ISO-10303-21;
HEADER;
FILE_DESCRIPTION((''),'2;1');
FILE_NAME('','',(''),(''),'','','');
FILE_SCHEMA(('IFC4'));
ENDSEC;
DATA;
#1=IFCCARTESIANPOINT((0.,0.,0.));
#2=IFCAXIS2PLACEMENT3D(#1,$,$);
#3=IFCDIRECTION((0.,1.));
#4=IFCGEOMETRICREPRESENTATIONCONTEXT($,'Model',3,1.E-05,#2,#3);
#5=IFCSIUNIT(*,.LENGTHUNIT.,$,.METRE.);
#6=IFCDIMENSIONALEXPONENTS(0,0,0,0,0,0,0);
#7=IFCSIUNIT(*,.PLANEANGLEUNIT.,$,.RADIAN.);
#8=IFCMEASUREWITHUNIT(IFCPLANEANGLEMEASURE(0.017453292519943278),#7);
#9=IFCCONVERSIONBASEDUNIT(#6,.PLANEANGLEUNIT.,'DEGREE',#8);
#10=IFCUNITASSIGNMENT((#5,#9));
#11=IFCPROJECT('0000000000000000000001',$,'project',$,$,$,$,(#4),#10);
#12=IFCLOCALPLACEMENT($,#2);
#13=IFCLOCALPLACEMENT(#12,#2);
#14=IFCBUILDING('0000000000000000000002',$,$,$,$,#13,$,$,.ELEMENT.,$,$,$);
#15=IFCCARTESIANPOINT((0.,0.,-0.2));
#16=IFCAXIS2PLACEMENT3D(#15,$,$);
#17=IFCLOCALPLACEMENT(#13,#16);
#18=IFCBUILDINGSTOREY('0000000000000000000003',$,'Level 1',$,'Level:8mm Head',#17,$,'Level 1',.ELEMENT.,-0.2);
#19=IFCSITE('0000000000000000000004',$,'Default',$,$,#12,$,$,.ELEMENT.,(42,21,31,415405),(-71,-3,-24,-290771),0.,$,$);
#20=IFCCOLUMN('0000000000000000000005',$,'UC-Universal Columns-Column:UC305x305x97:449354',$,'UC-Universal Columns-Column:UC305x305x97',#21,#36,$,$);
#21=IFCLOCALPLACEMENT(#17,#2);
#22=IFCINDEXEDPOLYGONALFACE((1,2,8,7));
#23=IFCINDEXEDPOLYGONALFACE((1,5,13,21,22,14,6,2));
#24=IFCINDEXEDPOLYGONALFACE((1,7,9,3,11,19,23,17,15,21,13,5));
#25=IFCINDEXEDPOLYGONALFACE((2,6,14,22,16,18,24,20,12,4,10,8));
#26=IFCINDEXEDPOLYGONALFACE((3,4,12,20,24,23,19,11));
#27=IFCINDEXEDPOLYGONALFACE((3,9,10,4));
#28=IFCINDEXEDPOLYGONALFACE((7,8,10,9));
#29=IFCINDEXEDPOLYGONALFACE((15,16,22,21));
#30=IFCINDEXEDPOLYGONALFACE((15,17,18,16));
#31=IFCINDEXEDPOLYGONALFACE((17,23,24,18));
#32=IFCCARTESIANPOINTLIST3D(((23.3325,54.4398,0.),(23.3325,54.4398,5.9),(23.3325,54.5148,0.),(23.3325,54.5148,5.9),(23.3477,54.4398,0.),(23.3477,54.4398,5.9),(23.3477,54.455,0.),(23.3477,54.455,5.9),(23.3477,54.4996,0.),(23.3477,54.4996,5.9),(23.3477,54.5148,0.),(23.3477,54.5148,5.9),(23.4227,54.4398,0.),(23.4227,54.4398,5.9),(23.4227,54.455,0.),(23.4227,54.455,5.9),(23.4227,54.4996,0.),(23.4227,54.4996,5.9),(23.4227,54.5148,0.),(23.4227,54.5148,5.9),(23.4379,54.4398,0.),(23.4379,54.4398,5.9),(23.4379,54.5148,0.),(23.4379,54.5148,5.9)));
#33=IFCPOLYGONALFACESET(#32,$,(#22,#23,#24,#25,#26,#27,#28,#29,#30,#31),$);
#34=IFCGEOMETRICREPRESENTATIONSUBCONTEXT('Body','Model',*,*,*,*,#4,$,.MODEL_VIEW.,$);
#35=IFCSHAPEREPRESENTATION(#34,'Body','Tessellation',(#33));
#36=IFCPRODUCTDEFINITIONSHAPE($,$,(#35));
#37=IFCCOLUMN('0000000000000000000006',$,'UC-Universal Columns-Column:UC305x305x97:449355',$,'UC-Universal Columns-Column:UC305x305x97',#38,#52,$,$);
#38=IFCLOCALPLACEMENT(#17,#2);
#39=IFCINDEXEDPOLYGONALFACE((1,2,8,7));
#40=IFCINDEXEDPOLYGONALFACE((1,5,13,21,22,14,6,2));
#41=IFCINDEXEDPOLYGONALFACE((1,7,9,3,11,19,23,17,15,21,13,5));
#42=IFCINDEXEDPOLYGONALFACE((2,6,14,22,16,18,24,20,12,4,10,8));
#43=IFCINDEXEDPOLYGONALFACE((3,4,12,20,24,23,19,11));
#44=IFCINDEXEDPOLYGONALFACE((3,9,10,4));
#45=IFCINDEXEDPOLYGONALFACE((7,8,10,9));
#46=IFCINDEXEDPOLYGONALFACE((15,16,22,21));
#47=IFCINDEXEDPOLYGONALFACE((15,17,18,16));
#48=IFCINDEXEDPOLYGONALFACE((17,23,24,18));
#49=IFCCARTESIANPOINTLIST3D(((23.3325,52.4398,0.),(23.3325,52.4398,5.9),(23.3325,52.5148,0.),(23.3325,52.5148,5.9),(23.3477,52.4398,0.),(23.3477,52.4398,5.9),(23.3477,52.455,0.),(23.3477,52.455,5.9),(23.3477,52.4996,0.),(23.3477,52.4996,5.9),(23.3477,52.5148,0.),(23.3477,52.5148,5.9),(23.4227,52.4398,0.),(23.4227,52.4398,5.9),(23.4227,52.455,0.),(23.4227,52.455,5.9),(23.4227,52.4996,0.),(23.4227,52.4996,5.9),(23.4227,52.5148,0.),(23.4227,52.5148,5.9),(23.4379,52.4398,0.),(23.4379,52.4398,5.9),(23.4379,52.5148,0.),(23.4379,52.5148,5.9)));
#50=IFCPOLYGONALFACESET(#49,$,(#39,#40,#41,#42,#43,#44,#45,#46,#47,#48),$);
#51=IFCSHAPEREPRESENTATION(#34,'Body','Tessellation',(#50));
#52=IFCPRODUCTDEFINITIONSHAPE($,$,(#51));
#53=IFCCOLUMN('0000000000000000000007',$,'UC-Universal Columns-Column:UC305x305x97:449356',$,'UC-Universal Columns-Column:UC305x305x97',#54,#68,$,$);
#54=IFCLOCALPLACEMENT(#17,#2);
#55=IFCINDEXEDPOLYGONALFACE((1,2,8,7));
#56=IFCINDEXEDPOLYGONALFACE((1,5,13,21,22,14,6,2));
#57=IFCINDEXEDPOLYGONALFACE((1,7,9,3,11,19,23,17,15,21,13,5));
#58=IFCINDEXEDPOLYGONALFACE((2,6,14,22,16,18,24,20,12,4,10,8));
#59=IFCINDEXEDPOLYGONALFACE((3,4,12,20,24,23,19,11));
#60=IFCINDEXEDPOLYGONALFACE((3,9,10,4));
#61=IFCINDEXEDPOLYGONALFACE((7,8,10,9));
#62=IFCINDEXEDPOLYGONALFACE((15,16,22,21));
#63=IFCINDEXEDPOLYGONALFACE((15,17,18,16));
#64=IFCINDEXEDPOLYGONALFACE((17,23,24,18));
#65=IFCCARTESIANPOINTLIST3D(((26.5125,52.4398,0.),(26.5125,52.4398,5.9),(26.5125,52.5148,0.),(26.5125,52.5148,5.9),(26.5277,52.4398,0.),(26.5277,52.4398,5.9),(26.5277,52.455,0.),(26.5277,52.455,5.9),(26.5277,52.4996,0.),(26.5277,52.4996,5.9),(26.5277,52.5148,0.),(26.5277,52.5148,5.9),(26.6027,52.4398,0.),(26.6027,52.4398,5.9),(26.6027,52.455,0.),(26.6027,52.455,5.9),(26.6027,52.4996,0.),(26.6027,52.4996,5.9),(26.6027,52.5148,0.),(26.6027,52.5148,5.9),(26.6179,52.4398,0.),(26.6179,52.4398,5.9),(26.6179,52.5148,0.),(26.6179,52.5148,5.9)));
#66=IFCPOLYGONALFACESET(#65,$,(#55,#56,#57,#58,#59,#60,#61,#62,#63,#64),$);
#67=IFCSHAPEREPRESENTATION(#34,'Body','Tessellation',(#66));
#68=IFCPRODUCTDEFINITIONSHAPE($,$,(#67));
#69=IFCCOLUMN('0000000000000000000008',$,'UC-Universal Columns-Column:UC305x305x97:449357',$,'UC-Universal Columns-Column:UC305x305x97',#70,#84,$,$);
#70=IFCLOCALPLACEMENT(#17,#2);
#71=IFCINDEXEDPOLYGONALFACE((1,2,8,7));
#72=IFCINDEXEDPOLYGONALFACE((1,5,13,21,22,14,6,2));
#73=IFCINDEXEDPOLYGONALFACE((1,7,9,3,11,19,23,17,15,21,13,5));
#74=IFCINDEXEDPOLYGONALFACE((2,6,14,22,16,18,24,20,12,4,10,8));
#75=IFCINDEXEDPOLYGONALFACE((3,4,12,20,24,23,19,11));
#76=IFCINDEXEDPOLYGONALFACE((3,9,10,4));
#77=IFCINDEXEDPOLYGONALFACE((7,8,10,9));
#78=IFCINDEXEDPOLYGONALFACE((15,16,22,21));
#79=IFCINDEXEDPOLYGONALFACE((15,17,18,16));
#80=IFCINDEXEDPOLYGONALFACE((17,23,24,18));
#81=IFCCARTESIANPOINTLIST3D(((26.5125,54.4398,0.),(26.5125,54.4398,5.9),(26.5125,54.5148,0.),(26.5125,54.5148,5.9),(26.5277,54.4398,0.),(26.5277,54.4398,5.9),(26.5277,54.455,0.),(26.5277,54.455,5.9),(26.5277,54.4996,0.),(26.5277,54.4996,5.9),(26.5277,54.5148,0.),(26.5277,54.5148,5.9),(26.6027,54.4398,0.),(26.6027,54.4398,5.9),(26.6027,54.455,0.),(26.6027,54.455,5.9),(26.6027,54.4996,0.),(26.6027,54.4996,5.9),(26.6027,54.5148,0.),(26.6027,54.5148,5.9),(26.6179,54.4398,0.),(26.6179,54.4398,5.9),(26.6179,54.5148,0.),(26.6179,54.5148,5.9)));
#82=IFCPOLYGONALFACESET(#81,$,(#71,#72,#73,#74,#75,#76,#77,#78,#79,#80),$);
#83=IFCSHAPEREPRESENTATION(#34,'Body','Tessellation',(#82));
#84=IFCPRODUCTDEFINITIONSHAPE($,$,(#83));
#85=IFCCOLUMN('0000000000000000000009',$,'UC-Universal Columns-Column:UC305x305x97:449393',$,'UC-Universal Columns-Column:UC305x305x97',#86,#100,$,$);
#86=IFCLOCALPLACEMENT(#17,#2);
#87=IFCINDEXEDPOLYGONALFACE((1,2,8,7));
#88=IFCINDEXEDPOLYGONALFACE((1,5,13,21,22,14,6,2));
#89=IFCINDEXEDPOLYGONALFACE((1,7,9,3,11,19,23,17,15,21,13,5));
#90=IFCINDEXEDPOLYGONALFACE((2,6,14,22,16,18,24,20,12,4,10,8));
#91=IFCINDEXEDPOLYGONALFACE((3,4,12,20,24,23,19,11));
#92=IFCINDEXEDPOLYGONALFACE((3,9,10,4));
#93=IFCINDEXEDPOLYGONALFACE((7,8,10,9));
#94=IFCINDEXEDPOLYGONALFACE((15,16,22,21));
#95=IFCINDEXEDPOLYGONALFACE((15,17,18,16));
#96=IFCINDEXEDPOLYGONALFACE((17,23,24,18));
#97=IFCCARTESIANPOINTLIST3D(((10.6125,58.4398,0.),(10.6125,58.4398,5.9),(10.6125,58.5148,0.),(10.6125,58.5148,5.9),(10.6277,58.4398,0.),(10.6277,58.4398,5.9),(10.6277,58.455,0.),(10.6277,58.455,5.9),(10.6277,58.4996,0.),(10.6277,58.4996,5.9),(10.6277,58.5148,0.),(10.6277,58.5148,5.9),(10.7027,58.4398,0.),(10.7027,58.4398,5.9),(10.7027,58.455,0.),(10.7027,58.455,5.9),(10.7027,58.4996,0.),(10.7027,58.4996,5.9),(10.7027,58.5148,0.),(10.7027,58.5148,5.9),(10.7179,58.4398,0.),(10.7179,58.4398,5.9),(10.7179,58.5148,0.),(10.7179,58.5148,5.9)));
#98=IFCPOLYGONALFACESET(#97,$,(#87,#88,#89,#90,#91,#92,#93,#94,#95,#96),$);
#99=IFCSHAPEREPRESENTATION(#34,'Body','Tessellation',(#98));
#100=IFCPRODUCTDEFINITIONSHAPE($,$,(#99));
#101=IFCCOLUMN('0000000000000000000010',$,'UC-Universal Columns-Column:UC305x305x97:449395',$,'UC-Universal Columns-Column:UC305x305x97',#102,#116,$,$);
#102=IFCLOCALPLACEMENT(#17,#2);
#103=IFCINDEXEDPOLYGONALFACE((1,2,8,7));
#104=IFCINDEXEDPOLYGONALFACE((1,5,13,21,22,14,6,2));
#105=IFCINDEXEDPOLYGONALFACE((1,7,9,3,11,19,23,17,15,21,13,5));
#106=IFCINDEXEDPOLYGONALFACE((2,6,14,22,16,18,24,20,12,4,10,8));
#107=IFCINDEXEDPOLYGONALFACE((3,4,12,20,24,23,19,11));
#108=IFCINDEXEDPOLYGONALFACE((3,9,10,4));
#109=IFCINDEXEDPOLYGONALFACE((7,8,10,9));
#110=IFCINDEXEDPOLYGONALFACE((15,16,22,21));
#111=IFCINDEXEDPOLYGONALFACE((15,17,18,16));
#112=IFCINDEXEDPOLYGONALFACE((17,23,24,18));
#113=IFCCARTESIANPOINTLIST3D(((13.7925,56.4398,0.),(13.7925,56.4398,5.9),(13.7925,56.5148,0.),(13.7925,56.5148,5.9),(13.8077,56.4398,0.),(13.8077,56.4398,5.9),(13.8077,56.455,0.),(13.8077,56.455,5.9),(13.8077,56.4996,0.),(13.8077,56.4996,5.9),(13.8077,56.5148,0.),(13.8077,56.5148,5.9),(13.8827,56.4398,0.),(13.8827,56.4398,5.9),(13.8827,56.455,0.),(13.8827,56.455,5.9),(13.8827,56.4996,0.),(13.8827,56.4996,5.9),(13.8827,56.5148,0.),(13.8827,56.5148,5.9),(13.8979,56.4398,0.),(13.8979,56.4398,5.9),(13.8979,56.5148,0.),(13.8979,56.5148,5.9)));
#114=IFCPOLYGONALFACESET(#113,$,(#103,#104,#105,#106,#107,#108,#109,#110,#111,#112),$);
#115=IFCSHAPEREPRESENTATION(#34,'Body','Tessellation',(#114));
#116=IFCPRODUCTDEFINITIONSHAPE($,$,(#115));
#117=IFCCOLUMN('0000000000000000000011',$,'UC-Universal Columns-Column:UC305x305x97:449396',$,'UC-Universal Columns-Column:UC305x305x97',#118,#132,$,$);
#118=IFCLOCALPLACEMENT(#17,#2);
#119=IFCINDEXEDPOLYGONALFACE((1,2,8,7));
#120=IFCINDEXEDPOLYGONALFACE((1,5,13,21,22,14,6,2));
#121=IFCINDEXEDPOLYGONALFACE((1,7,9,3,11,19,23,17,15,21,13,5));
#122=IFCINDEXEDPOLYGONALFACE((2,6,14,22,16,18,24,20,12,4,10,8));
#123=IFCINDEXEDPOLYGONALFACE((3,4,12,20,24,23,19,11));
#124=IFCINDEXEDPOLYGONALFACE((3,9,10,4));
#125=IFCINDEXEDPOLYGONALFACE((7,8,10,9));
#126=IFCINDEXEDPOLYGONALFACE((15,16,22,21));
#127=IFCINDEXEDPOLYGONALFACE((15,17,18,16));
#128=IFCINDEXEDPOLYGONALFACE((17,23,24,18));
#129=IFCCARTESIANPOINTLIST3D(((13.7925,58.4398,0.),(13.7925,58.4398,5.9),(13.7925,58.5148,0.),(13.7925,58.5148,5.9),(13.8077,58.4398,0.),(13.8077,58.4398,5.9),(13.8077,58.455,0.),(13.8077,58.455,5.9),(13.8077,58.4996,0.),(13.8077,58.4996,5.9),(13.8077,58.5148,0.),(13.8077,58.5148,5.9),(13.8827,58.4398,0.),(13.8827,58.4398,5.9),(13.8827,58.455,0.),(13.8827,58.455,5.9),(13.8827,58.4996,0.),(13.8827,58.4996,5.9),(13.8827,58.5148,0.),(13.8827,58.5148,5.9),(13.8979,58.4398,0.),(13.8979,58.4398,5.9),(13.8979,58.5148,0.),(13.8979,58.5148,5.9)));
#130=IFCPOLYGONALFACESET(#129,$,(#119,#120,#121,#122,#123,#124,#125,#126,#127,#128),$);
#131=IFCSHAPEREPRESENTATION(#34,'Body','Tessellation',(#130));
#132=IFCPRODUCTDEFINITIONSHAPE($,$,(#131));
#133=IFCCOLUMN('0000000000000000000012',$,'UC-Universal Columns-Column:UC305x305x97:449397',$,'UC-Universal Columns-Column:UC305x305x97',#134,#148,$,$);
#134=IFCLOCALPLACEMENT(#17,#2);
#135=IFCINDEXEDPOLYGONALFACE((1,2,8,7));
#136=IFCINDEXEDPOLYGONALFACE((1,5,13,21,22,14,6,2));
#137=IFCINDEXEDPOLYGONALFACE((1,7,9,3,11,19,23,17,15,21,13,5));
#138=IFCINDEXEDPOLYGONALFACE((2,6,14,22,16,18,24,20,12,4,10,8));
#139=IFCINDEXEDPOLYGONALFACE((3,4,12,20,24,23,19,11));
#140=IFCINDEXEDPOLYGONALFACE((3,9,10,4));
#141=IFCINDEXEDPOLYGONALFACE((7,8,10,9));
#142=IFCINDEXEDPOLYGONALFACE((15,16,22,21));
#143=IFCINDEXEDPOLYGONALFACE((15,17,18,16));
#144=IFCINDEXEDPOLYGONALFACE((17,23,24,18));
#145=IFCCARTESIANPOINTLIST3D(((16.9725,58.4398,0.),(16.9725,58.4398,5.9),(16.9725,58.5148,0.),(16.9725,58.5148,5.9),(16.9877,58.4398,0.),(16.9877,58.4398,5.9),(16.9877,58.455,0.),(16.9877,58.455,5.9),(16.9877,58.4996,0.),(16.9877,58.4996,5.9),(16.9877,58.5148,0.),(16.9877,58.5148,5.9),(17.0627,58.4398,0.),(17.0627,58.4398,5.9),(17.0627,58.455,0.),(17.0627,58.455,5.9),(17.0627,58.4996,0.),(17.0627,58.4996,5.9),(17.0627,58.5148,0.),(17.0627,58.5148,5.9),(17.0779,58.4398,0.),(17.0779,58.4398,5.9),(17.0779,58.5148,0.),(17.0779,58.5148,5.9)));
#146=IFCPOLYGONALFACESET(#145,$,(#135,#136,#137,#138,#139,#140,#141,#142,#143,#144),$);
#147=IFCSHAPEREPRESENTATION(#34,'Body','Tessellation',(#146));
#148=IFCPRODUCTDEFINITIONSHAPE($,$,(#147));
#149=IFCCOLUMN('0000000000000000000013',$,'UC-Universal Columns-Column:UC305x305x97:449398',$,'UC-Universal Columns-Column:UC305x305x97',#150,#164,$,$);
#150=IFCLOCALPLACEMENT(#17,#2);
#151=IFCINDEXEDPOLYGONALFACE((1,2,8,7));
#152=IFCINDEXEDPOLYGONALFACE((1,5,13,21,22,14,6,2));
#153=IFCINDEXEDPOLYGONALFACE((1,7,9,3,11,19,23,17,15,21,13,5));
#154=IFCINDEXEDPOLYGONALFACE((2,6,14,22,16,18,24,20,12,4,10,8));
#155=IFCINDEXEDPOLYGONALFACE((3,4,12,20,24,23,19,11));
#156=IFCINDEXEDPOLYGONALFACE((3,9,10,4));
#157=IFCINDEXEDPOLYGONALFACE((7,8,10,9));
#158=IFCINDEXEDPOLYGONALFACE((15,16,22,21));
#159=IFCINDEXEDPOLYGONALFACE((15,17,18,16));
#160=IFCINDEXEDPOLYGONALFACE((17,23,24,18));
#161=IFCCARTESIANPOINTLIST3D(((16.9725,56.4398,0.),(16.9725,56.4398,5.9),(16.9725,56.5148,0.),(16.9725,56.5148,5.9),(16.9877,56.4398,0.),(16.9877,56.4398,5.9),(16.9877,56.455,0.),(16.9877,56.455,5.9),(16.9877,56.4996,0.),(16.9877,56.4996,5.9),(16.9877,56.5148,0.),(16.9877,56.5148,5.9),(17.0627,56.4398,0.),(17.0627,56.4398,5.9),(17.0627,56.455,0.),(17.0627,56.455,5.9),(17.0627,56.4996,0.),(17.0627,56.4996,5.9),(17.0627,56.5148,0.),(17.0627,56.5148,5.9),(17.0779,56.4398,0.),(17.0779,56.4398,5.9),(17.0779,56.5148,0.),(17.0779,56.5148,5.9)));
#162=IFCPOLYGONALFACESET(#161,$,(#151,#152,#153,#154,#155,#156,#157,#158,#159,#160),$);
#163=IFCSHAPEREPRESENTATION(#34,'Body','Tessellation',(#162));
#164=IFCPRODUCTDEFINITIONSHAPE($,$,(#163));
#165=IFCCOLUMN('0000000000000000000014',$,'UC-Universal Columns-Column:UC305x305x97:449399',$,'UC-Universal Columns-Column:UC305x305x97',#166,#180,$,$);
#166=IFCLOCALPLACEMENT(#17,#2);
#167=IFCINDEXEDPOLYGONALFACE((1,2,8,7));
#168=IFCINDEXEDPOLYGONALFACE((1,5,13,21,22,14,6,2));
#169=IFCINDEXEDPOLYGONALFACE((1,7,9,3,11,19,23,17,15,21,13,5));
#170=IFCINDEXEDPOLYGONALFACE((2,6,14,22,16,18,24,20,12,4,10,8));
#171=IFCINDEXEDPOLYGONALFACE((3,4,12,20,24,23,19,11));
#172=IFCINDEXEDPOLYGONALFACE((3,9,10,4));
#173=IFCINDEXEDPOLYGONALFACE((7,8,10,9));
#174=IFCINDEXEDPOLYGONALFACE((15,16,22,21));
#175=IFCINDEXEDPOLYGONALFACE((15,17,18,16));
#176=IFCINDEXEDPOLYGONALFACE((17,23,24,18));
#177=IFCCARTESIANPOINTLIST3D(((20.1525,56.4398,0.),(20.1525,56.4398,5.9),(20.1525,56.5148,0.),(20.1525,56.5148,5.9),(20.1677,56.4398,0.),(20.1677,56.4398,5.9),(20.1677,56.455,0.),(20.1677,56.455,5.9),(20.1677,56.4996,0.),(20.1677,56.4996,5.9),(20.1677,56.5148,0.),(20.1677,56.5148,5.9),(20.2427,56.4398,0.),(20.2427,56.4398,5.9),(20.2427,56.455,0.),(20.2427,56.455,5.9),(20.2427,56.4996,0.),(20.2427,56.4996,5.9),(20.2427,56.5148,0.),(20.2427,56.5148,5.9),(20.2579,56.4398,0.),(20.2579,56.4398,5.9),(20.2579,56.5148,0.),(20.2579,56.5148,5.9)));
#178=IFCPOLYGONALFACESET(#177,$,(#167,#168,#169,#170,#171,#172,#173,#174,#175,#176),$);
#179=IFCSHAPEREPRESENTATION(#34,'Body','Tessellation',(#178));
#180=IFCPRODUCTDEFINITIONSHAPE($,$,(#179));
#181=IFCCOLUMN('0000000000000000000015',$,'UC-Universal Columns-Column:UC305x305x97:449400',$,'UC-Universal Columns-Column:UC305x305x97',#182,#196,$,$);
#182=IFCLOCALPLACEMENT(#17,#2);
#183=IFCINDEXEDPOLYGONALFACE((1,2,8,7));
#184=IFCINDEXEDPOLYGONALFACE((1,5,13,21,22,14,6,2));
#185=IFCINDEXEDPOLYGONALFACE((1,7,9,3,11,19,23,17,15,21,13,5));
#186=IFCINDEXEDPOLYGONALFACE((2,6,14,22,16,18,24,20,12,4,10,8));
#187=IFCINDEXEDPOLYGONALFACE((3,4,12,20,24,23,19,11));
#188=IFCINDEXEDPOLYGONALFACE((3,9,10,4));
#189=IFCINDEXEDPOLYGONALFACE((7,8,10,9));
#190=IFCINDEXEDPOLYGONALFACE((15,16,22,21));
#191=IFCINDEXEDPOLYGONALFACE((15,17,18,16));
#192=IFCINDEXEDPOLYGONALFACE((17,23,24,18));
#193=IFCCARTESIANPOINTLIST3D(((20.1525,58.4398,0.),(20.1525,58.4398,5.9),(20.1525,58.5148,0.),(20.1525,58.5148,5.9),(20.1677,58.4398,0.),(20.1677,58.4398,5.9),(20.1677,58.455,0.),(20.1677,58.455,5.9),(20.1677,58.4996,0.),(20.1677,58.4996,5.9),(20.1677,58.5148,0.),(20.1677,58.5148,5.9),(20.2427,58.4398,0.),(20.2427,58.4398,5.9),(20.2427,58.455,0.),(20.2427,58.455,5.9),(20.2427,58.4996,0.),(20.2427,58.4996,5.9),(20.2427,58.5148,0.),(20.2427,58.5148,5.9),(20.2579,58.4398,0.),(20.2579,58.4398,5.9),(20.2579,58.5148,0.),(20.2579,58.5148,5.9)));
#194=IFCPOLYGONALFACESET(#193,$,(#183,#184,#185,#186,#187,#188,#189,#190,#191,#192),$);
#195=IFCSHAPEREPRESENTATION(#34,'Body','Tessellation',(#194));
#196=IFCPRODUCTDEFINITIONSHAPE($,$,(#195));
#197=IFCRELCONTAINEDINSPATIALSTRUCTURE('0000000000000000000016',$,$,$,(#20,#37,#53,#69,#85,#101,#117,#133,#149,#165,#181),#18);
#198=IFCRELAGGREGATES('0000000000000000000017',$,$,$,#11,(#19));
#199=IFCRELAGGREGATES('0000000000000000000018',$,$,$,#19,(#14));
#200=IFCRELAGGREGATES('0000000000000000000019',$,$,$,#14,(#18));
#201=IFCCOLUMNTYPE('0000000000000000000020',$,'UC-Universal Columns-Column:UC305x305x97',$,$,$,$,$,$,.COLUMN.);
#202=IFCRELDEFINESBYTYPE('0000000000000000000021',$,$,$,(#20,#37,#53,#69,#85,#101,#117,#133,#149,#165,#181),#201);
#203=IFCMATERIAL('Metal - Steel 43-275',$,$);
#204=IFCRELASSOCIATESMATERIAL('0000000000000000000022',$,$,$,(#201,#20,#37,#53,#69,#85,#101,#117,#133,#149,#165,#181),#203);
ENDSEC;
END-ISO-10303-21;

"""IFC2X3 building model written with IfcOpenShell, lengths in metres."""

from ifc_helpers import new_model, entity, si_unit, converted_unit, direction, frame, frame_2d, origin, place, context, subcontext, project, spatial, polyline, circle_curve, parameter, trimmed, segment, composite_curve, outline, extrude, source, transform, mapped, material, type_object, type_shapes, element, save


model = new_model("IFC2X3")

# Units and contexts
model_context = context("Model", 3, precision=1e-05, world=origin(), true_north=direction((0.0, 1.0)))
body_context = subcontext(model_context, "Body", "Model", "MODEL_VIEW")
ifc_project = project(units=[si_unit("LENGTHUNIT", "METRE"), converted_unit("PLANEANGLEUNIT", "DEGREE", entity("IfcPlaneAngleMeasure", 0.017453292519943278), si_unit("PLANEANGLEUNIT", "RADIAN"), dimensions=[0, 0, 0, 0, 0, 0, 0])], contexts=[model_context])

# Site, building, storey
site_placement = place(None, origin())
site = spatial("IfcSite", under=ifc_project, at=site_placement, Name="Default", CompositionType="ELEMENT", RefLatitude=(42, 21, 31, 415405), RefLongitude=(-71, -3, -24, -290771), RefElevation=0.0)
building_placement = place(site_placement, origin())
building = spatial("IfcBuilding", under=site, at=building_placement, CompositionType="ELEMENT")
storey_placement = place(building_placement, frame((0.0, 0.0, -0.2)))
storey = spatial("IfcBuildingStorey", under=building, at=storey_placement, Name="Level 1", ObjectType="Level:8mm Head", LongName="Level 1", CompositionType="ELEMENT", Elevation=-0.2)

# Columns
ifc_material = material(Name="Metal - Steel 43-275")
column_type = type_object("IfcColumnType", Name="UC-Universal Columns-Column:UC305x305x97", PredefinedType="COLUMN", material=ifc_material)
shared_shape = source(origin(), body_context, "Body", "SweptSolid", [
    extrude(outline(composite_curve([segment(polyline([(-0.0375, -0.0375), (0.0375, -0.0375)]), True, "CONTINUOUS"), segment(polyline([(0.0375, -0.0375), (0.0527, -0.0375)]), True, "CONTINUOUS"), segment(trimmed(circle_curve(frame_2d((0.0527, -0.0223), x_axis=(-1.0, 0.0)), 0.0152), [parameter(0.0)], [parameter(90.0)], True, "PARAMETER"), False, "CONTINUOUS"), segment(polyline([(0.0375, -0.0223), (0.0375, 0.0223)]), True, "CONTINUOUS"), segment(trimmed(circle_curve(frame_2d((0.0527, 0.0223), x_axis=(-1.0, 0.0)), 0.0152), [parameter(270.0)], [parameter(0.0)], True, "PARAMETER"), False, "CONTINUOUS"), segment(polyline([(0.0527, 0.0375), (0.0375, 0.0375)]), True, "CONTINUOUS"), segment(polyline([(0.0375, 0.0375), (-0.0375, 0.0375)]), True, "CONTINUOUS"), segment(polyline([(-0.0375, 0.0375), (-0.0527, 0.0375)]), True, "CONTINUOUS"), segment(trimmed(circle_curve(frame_2d((-0.0527, 0.0223), x_axis=(-1.0, 0.0)), 0.0152), [parameter(180.0)], [parameter(270.0)], True, "PARAMETER"), False, "CONTINUOUS"), segment(polyline([(-0.0375, 0.0223), (-0.0375, -0.0223)]), True, "CONTINUOUS"), segment(trimmed(circle_curve(frame_2d((-0.0527, -0.0223), x_axis=(-1.0, 0.0)), 0.0152), [parameter(90.0)], [parameter(180.0)], True, "PARAMETER"), False, "CONTINUOUS"), segment(polyline([(-0.0527, -0.0375), (-0.0375, -0.0375)]), True, "CONTINUOUS")], self_intersect=False)), frame((0.0, 0.0, -0.2), z_axis=(0.0, 0.0, 1.0), x_axis=(-1.0, 0.0, 0.0)), (0.0, 0.0, 1.0), 5.9),
])
type_shapes(column_type, [shared_shape])
for number, where, z_axis, x_axis, name in (
    (1, (23.3852, 54.4773, 0.2), (0.0, 0.0, 1.0), (-1.0, 0.0, 0.0), "UC-Universal Columns-Column:UC305x305x97:449354"),
    (2, (23.3852, 52.4773, 0.2), (0.0, 0.0, 1.0), (-1.0, 0.0, 0.0), "UC-Universal Columns-Column:UC305x305x97:449355"),
    (3, (26.5652, 52.4773, 0.2), (0.0, 0.0, 1.0), (-1.0, 0.0, 0.0), "UC-Universal Columns-Column:UC305x305x97:449356"),
    (4, (26.5652, 54.4773, 0.2), (0.0, 0.0, 1.0), (-1.0, 0.0, 0.0), "UC-Universal Columns-Column:UC305x305x97:449357"),
    (5, (10.6652, 58.4773, 0.2), (0.0, 0.0, 1.0), (-1.0, 0.0, 0.0), "UC-Universal Columns-Column:UC305x305x97:449393"),
    (6, (13.8452, 56.4773, 0.2), (0.0, 0.0, 1.0), (-1.0, 0.0, 0.0), "UC-Universal Columns-Column:UC305x305x97:449395"),
    (7, (13.8452, 58.4773, 0.2), (0.0, 0.0, 1.0), (-1.0, 0.0, 0.0), "UC-Universal Columns-Column:UC305x305x97:449396"),
    (8, (17.0252, 58.4773, 0.2), (0.0, 0.0, 1.0), (-1.0, 0.0, 0.0), "UC-Universal Columns-Column:UC305x305x97:449397"),
    (9, (17.0252, 56.4773, 0.2), (0.0, 0.0, 1.0), (-1.0, 0.0, 0.0), "UC-Universal Columns-Column:UC305x305x97:449398"),
    (10, (20.2052, 56.4773, 0.2), (0.0, 0.0, 1.0), (-1.0, 0.0, 0.0), "UC-Universal Columns-Column:UC305x305x97:449399"),
    (11, (20.2052, 58.4773, 0.2), (0.0, 0.0, 1.0), (-1.0, 0.0, 0.0), "UC-Universal Columns-Column:UC305x305x97:449400"),
):
    element("IfcColumn", number, at=place(storey_placement, frame(where, z_axis=z_axis, x_axis=x_axis)), inside=storey, type_object=column_type, material=ifc_material, Name=name, ObjectType="UC-Universal Columns-Column:UC305x305x97", context=body_context, shape_type="MappedRepresentation", body=[
        mapped(shared_shape, transform((0.0, 0.0, 0.0), scale=1.0)),
    ])

save(model, "model.ifc")
